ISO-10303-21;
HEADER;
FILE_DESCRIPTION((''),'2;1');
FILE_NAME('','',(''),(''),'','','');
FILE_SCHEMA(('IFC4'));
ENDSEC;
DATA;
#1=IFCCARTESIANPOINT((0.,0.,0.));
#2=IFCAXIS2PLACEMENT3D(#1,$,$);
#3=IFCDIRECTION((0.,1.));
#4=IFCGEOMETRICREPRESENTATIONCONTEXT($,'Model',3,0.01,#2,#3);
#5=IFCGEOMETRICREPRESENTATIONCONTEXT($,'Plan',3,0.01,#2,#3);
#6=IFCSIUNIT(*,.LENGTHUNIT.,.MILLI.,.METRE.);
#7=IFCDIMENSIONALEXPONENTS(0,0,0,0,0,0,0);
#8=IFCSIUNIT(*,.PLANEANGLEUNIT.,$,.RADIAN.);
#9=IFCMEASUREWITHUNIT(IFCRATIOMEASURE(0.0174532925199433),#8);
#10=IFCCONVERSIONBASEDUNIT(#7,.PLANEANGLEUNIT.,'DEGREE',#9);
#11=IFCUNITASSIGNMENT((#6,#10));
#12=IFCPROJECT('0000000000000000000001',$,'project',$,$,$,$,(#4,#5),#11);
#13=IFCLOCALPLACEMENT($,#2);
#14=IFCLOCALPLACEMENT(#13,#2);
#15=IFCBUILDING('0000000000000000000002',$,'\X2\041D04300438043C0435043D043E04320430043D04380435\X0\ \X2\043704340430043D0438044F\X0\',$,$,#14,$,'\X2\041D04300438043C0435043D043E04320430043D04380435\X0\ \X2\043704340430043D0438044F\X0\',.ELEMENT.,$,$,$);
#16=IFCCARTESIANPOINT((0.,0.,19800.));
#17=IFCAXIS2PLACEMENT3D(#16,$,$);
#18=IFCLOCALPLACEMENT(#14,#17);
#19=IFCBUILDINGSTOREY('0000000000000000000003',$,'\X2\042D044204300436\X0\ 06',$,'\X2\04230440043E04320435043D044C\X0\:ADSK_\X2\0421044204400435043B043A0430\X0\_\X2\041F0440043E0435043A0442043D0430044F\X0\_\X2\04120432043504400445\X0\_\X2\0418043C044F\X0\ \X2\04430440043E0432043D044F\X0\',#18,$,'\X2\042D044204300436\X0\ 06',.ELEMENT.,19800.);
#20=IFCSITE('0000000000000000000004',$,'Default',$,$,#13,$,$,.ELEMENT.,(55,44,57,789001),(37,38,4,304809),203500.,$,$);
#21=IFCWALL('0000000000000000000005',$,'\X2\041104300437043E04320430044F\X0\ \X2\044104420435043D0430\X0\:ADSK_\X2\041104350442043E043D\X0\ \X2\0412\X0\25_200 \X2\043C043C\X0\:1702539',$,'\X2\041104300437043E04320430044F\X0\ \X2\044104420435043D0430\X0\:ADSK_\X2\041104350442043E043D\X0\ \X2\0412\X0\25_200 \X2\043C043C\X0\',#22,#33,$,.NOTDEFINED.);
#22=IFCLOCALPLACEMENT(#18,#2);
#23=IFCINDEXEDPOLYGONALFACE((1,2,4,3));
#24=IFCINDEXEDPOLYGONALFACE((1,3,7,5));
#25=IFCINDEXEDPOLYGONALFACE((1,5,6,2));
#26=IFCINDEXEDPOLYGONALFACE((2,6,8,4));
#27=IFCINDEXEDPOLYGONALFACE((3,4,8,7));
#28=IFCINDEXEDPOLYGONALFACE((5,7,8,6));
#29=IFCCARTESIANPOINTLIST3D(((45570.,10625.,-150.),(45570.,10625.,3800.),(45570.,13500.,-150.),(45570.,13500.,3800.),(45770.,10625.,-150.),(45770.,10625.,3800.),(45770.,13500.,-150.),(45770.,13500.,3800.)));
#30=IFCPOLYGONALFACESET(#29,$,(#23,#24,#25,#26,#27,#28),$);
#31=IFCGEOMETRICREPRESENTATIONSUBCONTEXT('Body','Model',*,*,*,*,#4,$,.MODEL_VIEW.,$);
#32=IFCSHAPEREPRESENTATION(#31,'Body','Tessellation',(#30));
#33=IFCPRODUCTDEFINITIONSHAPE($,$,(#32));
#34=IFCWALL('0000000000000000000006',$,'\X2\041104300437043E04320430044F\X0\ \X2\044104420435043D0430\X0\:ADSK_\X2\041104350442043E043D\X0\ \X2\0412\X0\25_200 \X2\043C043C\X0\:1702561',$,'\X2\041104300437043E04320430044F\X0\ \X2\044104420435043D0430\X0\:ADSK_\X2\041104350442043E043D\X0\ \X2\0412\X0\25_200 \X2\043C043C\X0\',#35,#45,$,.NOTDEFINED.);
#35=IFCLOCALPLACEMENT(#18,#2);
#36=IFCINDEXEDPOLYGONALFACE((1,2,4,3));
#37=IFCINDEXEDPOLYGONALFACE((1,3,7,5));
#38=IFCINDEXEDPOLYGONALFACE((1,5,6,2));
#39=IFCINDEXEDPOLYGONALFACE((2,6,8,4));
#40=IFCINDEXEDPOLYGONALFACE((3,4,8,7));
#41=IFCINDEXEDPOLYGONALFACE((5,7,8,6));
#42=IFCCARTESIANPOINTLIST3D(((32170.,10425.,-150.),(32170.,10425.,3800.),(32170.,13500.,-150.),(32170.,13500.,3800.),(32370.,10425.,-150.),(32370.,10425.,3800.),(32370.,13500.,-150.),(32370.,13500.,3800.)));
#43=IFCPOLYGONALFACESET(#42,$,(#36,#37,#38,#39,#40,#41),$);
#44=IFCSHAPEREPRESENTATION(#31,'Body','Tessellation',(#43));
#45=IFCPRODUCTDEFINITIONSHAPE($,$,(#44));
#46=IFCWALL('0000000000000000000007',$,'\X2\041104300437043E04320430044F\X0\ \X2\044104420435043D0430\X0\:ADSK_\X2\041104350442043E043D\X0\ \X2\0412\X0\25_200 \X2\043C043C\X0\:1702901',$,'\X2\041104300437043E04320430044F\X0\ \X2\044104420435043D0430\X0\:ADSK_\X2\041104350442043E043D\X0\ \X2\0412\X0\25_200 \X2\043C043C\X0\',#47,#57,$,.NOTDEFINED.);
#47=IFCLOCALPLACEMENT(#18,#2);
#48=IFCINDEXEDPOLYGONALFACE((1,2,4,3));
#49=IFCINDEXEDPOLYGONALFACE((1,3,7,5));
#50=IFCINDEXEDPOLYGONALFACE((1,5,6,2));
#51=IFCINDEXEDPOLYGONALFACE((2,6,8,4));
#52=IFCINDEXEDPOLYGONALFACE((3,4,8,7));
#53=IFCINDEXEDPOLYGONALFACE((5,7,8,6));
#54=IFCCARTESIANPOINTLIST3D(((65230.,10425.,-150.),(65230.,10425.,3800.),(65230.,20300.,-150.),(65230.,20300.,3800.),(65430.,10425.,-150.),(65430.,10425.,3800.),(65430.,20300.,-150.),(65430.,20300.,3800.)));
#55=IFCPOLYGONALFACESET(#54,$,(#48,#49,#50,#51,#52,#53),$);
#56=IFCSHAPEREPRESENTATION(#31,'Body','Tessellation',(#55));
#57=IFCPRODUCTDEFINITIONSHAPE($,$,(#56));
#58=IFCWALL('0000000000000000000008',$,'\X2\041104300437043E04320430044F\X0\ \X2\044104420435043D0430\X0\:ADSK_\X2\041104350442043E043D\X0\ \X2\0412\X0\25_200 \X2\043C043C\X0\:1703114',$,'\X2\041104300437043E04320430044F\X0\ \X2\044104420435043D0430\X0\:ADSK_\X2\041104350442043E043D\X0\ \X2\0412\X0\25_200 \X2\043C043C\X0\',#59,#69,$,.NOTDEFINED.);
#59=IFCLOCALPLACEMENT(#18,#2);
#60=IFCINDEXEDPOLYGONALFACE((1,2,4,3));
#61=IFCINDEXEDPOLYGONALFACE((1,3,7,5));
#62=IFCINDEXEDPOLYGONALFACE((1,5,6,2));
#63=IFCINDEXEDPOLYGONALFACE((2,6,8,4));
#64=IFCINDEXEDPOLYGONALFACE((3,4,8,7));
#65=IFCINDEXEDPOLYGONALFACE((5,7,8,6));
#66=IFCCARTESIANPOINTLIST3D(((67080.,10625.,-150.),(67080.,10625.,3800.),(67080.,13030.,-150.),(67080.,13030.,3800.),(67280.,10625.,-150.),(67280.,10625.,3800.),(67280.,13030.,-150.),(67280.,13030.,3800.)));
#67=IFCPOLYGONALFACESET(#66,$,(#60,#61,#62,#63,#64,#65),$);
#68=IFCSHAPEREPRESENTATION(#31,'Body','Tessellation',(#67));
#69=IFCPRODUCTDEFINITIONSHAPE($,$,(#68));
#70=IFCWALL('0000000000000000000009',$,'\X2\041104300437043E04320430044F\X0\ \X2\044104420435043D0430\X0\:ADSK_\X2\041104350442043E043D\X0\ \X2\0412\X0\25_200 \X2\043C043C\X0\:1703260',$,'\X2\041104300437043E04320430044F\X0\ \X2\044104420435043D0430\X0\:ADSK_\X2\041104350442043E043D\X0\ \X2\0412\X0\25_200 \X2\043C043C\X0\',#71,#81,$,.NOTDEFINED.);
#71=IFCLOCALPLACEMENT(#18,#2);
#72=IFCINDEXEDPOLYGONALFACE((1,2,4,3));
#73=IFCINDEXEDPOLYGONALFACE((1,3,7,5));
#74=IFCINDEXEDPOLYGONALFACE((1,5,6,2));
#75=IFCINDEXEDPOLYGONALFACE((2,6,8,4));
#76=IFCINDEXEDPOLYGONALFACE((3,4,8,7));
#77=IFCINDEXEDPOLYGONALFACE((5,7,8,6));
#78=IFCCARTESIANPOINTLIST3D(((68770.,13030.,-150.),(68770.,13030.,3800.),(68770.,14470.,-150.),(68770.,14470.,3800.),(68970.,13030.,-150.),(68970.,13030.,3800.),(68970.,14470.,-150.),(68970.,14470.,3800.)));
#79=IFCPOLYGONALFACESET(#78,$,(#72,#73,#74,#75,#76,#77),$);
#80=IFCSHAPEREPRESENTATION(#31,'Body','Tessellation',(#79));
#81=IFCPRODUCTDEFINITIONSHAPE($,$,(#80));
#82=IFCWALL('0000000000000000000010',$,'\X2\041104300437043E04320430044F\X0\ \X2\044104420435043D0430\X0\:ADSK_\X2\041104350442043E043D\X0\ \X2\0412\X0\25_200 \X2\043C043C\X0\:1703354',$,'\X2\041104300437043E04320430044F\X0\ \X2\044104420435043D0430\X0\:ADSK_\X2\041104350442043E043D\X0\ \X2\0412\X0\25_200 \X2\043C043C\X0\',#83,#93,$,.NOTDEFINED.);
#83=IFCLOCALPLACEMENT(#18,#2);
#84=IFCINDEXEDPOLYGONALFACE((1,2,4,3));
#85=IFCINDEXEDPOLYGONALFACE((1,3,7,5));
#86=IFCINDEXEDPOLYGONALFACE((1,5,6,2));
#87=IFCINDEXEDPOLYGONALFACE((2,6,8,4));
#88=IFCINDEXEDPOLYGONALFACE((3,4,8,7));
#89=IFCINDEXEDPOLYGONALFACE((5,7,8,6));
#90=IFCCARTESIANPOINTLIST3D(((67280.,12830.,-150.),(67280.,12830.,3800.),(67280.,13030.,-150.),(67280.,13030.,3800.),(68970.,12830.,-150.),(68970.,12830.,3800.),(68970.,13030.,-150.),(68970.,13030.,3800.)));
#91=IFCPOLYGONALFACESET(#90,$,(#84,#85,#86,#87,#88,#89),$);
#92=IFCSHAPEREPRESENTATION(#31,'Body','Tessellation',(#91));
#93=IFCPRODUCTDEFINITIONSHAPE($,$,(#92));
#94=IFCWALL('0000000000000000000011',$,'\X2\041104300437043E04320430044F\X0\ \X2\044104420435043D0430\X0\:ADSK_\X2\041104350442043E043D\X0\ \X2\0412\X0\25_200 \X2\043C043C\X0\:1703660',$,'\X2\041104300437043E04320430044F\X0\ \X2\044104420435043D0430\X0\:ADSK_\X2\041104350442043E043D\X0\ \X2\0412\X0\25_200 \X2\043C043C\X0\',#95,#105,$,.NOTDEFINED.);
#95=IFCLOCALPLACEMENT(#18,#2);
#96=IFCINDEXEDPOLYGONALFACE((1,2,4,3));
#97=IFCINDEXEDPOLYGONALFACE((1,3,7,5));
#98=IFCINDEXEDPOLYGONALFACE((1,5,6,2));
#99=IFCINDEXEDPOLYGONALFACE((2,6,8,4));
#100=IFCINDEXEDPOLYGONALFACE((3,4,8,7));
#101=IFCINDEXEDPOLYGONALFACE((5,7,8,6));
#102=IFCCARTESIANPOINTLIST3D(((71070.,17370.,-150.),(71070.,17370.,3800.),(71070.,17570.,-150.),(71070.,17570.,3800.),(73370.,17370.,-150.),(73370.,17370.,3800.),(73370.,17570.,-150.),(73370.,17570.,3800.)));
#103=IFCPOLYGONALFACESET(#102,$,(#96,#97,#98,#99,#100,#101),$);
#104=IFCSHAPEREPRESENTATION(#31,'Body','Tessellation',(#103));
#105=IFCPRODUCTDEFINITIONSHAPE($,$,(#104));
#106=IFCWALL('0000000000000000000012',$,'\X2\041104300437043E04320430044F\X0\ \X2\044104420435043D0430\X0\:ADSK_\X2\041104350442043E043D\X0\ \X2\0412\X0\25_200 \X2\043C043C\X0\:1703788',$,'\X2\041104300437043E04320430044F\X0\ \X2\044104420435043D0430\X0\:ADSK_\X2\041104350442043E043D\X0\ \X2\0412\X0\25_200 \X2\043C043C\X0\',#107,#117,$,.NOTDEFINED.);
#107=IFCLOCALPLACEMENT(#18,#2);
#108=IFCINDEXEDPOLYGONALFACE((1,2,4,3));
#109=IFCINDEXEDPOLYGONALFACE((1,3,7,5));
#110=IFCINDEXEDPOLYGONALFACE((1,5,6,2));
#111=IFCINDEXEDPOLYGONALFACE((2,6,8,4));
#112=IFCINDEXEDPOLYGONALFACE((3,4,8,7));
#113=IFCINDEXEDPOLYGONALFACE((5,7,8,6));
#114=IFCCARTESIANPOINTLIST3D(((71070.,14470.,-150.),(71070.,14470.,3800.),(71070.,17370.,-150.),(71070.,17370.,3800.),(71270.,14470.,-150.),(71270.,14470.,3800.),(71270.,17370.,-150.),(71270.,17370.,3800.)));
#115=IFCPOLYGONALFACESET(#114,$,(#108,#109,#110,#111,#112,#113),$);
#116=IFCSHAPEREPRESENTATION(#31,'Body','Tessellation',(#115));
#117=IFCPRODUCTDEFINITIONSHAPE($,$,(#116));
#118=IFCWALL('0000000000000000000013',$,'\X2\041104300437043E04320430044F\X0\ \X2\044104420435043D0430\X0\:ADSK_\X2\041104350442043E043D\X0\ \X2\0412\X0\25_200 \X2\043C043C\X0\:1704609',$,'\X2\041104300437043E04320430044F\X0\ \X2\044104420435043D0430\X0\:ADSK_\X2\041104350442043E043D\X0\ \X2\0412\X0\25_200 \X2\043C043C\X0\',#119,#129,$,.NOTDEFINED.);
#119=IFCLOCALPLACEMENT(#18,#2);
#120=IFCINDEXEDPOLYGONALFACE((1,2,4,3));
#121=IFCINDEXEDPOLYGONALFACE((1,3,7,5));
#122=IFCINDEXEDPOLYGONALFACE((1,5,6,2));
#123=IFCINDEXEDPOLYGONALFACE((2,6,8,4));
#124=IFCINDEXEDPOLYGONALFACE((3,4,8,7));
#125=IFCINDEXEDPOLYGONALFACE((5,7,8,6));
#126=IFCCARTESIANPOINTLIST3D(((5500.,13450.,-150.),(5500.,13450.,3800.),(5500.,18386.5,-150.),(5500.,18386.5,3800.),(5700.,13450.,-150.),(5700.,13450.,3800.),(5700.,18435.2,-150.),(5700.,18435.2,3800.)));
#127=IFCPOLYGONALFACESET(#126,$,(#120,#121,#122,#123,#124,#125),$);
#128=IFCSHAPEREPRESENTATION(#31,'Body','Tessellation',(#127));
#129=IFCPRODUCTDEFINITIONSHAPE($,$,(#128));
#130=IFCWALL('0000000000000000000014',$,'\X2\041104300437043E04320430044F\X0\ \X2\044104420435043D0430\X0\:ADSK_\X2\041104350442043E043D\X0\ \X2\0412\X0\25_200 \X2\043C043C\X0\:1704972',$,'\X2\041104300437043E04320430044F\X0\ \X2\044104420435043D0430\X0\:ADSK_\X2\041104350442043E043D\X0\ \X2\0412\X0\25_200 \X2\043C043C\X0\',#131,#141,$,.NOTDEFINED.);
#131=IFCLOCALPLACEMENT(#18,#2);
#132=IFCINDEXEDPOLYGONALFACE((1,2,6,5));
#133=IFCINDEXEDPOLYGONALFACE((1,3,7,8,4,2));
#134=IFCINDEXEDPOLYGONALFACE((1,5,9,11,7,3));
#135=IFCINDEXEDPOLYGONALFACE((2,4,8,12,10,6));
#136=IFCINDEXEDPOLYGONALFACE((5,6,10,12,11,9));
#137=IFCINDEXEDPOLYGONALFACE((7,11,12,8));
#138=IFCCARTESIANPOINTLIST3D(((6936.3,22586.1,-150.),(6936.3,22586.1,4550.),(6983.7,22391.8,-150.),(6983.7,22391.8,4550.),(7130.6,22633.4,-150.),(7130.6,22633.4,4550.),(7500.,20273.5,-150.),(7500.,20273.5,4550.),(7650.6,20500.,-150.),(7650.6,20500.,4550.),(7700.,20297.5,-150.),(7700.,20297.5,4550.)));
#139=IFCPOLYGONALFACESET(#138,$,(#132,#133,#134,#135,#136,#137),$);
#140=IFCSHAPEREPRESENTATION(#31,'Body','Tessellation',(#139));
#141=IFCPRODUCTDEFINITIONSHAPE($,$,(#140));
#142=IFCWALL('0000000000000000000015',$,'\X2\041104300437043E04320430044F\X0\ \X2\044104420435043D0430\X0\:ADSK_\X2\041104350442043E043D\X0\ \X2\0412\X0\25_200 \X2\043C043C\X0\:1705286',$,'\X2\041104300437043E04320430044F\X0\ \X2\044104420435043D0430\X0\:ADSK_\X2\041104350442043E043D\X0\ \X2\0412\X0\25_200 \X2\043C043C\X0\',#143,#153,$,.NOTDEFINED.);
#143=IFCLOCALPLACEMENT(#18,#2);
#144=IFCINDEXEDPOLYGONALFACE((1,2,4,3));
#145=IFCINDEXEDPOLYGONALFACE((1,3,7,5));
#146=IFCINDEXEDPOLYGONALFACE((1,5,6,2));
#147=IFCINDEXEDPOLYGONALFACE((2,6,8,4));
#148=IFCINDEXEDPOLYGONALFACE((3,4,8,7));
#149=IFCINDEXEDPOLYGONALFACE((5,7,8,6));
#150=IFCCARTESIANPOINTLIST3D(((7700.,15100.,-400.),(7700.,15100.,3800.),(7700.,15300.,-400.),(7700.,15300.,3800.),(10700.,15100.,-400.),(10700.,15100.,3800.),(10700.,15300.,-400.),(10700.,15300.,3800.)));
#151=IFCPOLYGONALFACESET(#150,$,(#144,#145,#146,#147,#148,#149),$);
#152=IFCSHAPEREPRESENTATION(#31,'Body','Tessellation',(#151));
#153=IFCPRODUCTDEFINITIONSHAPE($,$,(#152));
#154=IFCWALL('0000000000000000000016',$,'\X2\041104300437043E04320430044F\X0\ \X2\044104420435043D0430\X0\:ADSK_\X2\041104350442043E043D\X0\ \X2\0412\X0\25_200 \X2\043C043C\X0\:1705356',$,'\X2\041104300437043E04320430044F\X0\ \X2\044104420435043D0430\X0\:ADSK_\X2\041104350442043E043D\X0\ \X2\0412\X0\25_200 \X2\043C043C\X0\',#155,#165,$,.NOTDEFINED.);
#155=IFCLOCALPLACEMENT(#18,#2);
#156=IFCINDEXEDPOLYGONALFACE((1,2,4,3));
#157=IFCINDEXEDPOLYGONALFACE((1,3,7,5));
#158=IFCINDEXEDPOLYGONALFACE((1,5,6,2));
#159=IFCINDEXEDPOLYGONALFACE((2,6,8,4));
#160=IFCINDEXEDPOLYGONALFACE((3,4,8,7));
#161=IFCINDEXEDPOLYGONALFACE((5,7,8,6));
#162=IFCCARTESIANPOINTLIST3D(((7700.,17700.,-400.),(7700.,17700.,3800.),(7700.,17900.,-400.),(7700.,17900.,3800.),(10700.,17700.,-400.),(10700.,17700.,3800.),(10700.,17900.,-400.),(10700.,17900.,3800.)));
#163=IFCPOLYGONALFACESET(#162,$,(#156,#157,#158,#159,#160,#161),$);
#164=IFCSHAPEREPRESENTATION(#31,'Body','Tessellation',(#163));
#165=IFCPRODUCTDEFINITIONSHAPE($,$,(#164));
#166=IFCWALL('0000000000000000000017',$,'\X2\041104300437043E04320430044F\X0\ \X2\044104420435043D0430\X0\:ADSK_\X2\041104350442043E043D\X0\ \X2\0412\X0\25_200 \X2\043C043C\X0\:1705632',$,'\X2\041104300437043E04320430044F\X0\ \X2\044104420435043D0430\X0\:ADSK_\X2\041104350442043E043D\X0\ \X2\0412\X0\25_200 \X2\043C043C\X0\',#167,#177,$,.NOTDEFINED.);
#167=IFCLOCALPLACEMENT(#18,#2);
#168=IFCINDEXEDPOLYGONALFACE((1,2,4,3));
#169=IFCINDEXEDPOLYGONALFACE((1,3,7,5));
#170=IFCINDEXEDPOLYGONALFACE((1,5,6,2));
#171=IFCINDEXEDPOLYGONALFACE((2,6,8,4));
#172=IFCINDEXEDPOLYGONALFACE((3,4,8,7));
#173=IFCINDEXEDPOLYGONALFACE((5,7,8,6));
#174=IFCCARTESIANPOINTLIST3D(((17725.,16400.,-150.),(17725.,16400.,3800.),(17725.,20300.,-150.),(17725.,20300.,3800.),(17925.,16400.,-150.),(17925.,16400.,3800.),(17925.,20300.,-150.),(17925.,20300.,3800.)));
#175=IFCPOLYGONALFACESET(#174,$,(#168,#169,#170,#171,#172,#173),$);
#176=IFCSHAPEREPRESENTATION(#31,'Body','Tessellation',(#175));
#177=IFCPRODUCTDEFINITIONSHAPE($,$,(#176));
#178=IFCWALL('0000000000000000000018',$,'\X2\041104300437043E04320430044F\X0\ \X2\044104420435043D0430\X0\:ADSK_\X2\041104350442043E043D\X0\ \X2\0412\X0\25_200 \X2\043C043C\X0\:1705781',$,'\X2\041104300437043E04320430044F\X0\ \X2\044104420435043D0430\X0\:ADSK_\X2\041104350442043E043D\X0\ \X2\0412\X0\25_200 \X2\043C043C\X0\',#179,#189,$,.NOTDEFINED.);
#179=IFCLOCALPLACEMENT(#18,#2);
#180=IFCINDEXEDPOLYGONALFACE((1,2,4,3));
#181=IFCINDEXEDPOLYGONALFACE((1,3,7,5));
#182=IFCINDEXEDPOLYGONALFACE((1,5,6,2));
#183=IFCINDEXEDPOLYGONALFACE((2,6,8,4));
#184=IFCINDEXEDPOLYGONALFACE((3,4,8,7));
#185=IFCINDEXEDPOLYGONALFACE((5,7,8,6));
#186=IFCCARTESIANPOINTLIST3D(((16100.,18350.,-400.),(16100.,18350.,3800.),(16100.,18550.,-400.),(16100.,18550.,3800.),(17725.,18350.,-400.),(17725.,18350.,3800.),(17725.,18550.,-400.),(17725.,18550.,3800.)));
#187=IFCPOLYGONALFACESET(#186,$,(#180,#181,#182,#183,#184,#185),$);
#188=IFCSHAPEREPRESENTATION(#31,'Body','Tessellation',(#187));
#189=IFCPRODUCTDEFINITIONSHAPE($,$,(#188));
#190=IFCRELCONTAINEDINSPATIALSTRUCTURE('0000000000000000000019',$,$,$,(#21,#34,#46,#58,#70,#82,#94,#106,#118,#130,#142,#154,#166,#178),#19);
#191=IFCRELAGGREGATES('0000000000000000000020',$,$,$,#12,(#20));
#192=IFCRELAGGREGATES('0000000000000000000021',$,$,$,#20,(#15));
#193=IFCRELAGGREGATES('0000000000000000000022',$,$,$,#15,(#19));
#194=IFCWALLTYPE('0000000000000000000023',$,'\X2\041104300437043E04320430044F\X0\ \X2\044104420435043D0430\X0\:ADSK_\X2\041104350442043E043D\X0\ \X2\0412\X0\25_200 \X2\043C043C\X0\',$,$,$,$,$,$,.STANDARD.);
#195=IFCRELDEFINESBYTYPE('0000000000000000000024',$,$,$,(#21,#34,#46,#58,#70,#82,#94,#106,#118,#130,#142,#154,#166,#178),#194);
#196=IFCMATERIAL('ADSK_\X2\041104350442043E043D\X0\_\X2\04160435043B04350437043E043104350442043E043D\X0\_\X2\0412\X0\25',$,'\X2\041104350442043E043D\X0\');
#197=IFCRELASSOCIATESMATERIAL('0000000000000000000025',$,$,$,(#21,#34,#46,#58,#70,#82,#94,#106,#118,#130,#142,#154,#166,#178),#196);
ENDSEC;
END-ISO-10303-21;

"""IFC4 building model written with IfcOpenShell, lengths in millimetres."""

from ifc_helpers import new_model, entity, si_unit, converted_unit, direction, frame, origin, place, context, subcontext, project, spatial, indexed_curve, outline, extrude, material, type_object, element, save


model = new_model("IFC4")

# Units and contexts
model_context = context("Model", 3, precision=0.01, world=origin(), true_north=direction((0.0, 1.0)))
plan_context = context("Plan", 3, precision=0.01, world=origin(), true_north=direction((0.0, 1.0)))
body_context = subcontext(model_context, "Body", "Model", "MODEL_VIEW")
ifc_project = project(units=[si_unit("LENGTHUNIT", "METRE", prefix="MILLI"), converted_unit("PLANEANGLEUNIT", "DEGREE", entity("IfcRatioMeasure", 0.0174532925199433), si_unit("PLANEANGLEUNIT", "RADIAN"), dimensions=[0, 0, 0, 0, 0, 0, 0])], contexts=[model_context, plan_context])

# Site, building, storey
site_placement = place(None, origin())
site = spatial("IfcSite", under=ifc_project, at=site_placement, Name="Default", CompositionType="ELEMENT", RefLatitude=(55, 44, 57, 789001), RefLongitude=(37, 38, 4, 304809), RefElevation=203500.0)
building_placement = place(site_placement, origin())
building = spatial("IfcBuilding", under=site, at=building_placement, Name="Наименование здания", LongName="Наименование здания", CompositionType="ELEMENT")
storey_placement = place(building_placement, frame((0.0, 0.0, 19800.0)))
storey = spatial("IfcBuildingStorey", under=building, at=storey_placement, Name="Этаж 06", ObjectType="Уровень:ADSK_Стрелка_Проектная_Вверх_Имя уровня", LongName="Этаж 06", CompositionType="ELEMENT", Elevation=19800.0)

# Walls
ifc_material = material(Name="ADSK_Бетон_Железобетон_В25", Category="Бетон")
wall_type_1 = type_object("IfcWallType", Name="Базовая стена:ADSK_Бетон В25_200 мм", PredefinedType="STANDARD")
wall_1_placement = place(storey_placement, frame((45670.0, 13500.0, -150.0), z_axis=(0.0, 0.0, 1.0), x_axis=(0.0, -1.0, 0.0)))
element("IfcWall", 1, at=wall_1_placement, inside=storey, type_object=wall_type_1, material=ifc_material, Name="Базовая стена:ADSK_Бетон В25_200 мм:1702539", ObjectType="Базовая стена:ADSK_Бетон В25_200 мм", PredefinedType="NOTDEFINED", context=body_context, shape_type="SweptSolid", body=[
    extrude(outline(indexed_curve([(2875.0, 100.0), (0.0, 100.0), (0.0, -100.0), (2875.0, -100.0), (2875.0, 100.0)], self_intersect=False)), origin(), (0.0, 0.0, 1.0), 3950.0),
])
wall_2_placement = place(storey_placement, frame((32270.0, 13500.0, -150.0), z_axis=(0.0, 0.0, 1.0), x_axis=(0.0, -1.0, 0.0)))
element("IfcWall", 2, at=wall_2_placement, inside=storey, type_object=wall_type_1, material=ifc_material, Name="Базовая стена:ADSK_Бетон В25_200 мм:1702561", ObjectType="Базовая стена:ADSK_Бетон В25_200 мм", PredefinedType="NOTDEFINED", context=body_context, shape_type="SweptSolid", body=[
    extrude(outline(indexed_curve([(3075.0, 100.0), (0.0, 100.0), (0.0, -100.0), (3075.0, -100.0), (3075.0, 100.0)], self_intersect=False)), origin(), (0.0, 0.0, 1.0), 3950.0),
])
wall_3_placement = place(storey_placement, frame((65330.0, 20300.0, -150.0), z_axis=(0.0, 0.0, 1.0), x_axis=(0.0, -1.0, 0.0)))
element("IfcWall", 3, at=wall_3_placement, inside=storey, type_object=wall_type_1, material=ifc_material, Name="Базовая стена:ADSK_Бетон В25_200 мм:1702901", ObjectType="Базовая стена:ADSK_Бетон В25_200 мм", PredefinedType="NOTDEFINED", context=body_context, shape_type="SweptSolid", body=[
    extrude(outline(indexed_curve([(9875.0, 100.0), (0.0, 100.0), (0.0, -100.0), (9875.0, -100.0), (9875.0, 100.0)], self_intersect=False)), origin(), (0.0, 0.0, 1.0), 3950.0),
])
wall_4_placement = place(storey_placement, frame((67180.0, 10625.0, -150.0), z_axis=(0.0, 0.0, 1.0), x_axis=(0.0, 1.0, 0.0)))
element("IfcWall", 4, at=wall_4_placement, inside=storey, type_object=wall_type_1, material=ifc_material, Name="Базовая стена:ADSK_Бетон В25_200 мм:1703114", ObjectType="Базовая стена:ADSK_Бетон В25_200 мм", PredefinedType="NOTDEFINED", context=body_context, shape_type="SweptSolid", body=[
    extrude(outline(indexed_curve([(2405.0, 100.0), (0.0, 100.0), (0.0, -100.0), (2405.0, -100.0), (2405.0, 100.0)], self_intersect=False)), origin(), (0.0, 0.0, 1.0), 3950.0),
])
wall_5_placement = place(storey_placement, frame((68870.0, 13030.0, -150.0), z_axis=(0.0, 0.0, 1.0), x_axis=(0.0, 1.0, 0.0)))
element("IfcWall", 5, at=wall_5_placement, inside=storey, type_object=wall_type_1, material=ifc_material, Name="Базовая стена:ADSK_Бетон В25_200 мм:1703260", ObjectType="Базовая стена:ADSK_Бетон В25_200 мм", PredefinedType="NOTDEFINED", context=body_context, shape_type="SweptSolid", body=[
    extrude(outline(indexed_curve([(1440.0, 100.0), (0.0, 100.0), (0.0, -100.0), (1440.0, -100.0), (1440.0, 100.0)], self_intersect=False)), origin(), (0.0, 0.0, 1.0), 3950.0),
])
wall_6_placement = place(storey_placement, frame((68970.0, 12930.0, -150.0), z_axis=(0.0, 0.0, 1.0), x_axis=(-1.0, 0.0, 0.0)))
element("IfcWall", 6, at=wall_6_placement, inside=storey, type_object=wall_type_1, material=ifc_material, Name="Базовая стена:ADSK_Бетон В25_200 мм:1703354", ObjectType="Базовая стена:ADSK_Бетон В25_200 мм", PredefinedType="NOTDEFINED", context=body_context, shape_type="SweptSolid", body=[
    extrude(outline(indexed_curve([(1690.0, 100.0), (0.0, 100.0), (0.0, -100.0), (1690.0, -100.0), (1690.0, 100.0)], self_intersect=False)), origin(), (0.0, 0.0, 1.0), 3950.0),
])
wall_7_placement = place(storey_placement, frame((73370.0, 17470.0, -150.0), z_axis=(0.0, 0.0, 1.0), x_axis=(-1.0, 0.0, 0.0)))
element("IfcWall", 7, at=wall_7_placement, inside=storey, type_object=wall_type_1, material=ifc_material, Name="Базовая стена:ADSK_Бетон В25_200 мм:1703660", ObjectType="Базовая стена:ADSK_Бетон В25_200 мм", PredefinedType="NOTDEFINED", context=body_context, shape_type="SweptSolid", body=[
    extrude(outline(indexed_curve([(2300.0, 100.0), (0.0, 100.0), (0.0, -100.0), (2300.0, -100.0), (2300.0, 100.0)], self_intersect=False)), origin(), (0.0, 0.0, 1.0), 3950.0),
])
wall_8_placement = place(storey_placement, frame((71170.0, 14470.0, -150.0), z_axis=(0.0, 0.0, 1.0), x_axis=(0.0, 1.0, 0.0)))
element("IfcWall", 8, at=wall_8_placement, inside=storey, type_object=wall_type_1, material=ifc_material, Name="Базовая стена:ADSK_Бетон В25_200 мм:1703788", ObjectType="Базовая стена:ADSK_Бетон В25_200 мм", PredefinedType="NOTDEFINED", context=body_context, shape_type="SweptSolid", body=[
    extrude(outline(indexed_curve([(2900.0, 100.0), (0.0, 100.0), (0.0, -100.0), (2900.0, -100.0), (2900.0, 100.0)], self_intersect=False)), origin(), (0.0, 0.0, 1.0), 3950.0),
])
wall_9_placement = place(storey_placement, frame((5600.0, 18435.2, -150.0), z_axis=(0.0, 0.0, 1.0), x_axis=(0.0, -1.0, 0.0)))
element("IfcWall", 9, at=wall_9_placement, inside=storey, type_object=wall_type_1, material=ifc_material, Name="Базовая стена:ADSK_Бетон В25_200 мм:1704609", ObjectType="Базовая стена:ADSK_Бетон В25_200 мм", PredefinedType="NOTDEFINED", context=body_context, shape_type="SweptSolid", body=[
    extrude(outline(indexed_curve([(4985.2, -100.0), (4985.2, 100.0), (0.0, 100.0), (48.8, -100.0), (4985.2, -100.0)], self_intersect=False)), origin(), (0.0, 0.0, 1.0), 3950.0),
])
wall_10_placement = place(storey_placement, frame((7033.4, 22609.8, -150.0), z_axis=(0.0, 0.0, 1.0), x_axis=(0.236826, -0.971552, 0.0)))
element("IfcWall", 10, at=wall_10_placement, inside=storey, type_object=wall_type_1, material=ifc_material, Name="Базовая стена:ADSK_Бетон В25_200 мм:1704972", ObjectType="Базовая стена:ADSK_Бетон В25_200 мм", PredefinedType="NOTDEFINED", context=body_context, shape_type="SweptSolid", body=[
    extrude(outline(indexed_curve([(2380.3, -100.0), (2404.3, 100.0), (2195.9, 100.0), (0.0, 100.0), (0.0, -100.0), (200.0, -100.0), (2380.3, -100.0)], self_intersect=False)), origin(), (0.0, 0.0, 1.0), 4700.0),
])
wall_11_placement = place(storey_placement, frame((7700.0, 15200.0, -400.0)))
element("IfcWall", 11, at=wall_11_placement, inside=storey, type_object=wall_type_1, material=ifc_material, Name="Базовая стена:ADSK_Бетон В25_200 мм:1705286", ObjectType="Базовая стена:ADSK_Бетон В25_200 мм", PredefinedType="NOTDEFINED", context=body_context, shape_type="SweptSolid", body=[
    extrude(outline(indexed_curve([(3000.0, 100.0), (0.0, 100.0), (0.0, -100.0), (3000.0, -100.0), (3000.0, 100.0)], self_intersect=False)), origin(), (0.0, 0.0, 1.0), 4200.0),
])
wall_12_placement = place(storey_placement, frame((7700.0, 17800.0, -400.0)))
element("IfcWall", 12, at=wall_12_placement, inside=storey, type_object=wall_type_1, material=ifc_material, Name="Базовая стена:ADSK_Бетон В25_200 мм:1705356", ObjectType="Базовая стена:ADSK_Бетон В25_200 мм", PredefinedType="NOTDEFINED", context=body_context, shape_type="SweptSolid", body=[
    extrude(outline(indexed_curve([(3000.0, 100.0), (0.0, 100.0), (0.0, -100.0), (3000.0, -100.0), (3000.0, 100.0)], self_intersect=False)), origin(), (0.0, 0.0, 1.0), 4200.0),
])
wall_13_placement = place(storey_placement, frame((17825.0, 20300.0, -150.0), z_axis=(0.0, 0.0, 1.0), x_axis=(0.0, -1.0, 0.0)))
element("IfcWall", 13, at=wall_13_placement, inside=storey, type_object=wall_type_1, material=ifc_material, Name="Базовая стена:ADSK_Бетон В25_200 мм:1705632", ObjectType="Базовая стена:ADSK_Бетон В25_200 мм", PredefinedType="NOTDEFINED", context=body_context, shape_type="SweptSolid", body=[
    extrude(outline(indexed_curve([(3900.0, 100.0), (0.0, 100.0), (0.0, -100.0), (3900.0, -100.0), (3900.0, 100.0)], self_intersect=False)), origin(), (0.0, 0.0, 1.0), 3950.0),
])
wall_14_placement = place(storey_placement, frame((17725.0, 18450.0, -400.0), z_axis=(0.0, 0.0, 1.0), x_axis=(-1.0, 0.0, 0.0)))
element("IfcWall", 14, at=wall_14_placement, inside=storey, type_object=wall_type_1, material=ifc_material, Name="Базовая стена:ADSK_Бетон В25_200 мм:1705781", ObjectType="Базовая стена:ADSK_Бетон В25_200 мм", PredefinedType="NOTDEFINED", context=body_context, shape_type="SweptSolid", body=[
    extrude(outline(indexed_curve([(1625.0, 100.0), (0.0, 100.0), (0.0, -100.0), (1625.0, -100.0), (1625.0, 100.0)], self_intersect=False)), origin(), (0.0, 0.0, 1.0), 4200.0),
])

save(model, "model.ifc")
